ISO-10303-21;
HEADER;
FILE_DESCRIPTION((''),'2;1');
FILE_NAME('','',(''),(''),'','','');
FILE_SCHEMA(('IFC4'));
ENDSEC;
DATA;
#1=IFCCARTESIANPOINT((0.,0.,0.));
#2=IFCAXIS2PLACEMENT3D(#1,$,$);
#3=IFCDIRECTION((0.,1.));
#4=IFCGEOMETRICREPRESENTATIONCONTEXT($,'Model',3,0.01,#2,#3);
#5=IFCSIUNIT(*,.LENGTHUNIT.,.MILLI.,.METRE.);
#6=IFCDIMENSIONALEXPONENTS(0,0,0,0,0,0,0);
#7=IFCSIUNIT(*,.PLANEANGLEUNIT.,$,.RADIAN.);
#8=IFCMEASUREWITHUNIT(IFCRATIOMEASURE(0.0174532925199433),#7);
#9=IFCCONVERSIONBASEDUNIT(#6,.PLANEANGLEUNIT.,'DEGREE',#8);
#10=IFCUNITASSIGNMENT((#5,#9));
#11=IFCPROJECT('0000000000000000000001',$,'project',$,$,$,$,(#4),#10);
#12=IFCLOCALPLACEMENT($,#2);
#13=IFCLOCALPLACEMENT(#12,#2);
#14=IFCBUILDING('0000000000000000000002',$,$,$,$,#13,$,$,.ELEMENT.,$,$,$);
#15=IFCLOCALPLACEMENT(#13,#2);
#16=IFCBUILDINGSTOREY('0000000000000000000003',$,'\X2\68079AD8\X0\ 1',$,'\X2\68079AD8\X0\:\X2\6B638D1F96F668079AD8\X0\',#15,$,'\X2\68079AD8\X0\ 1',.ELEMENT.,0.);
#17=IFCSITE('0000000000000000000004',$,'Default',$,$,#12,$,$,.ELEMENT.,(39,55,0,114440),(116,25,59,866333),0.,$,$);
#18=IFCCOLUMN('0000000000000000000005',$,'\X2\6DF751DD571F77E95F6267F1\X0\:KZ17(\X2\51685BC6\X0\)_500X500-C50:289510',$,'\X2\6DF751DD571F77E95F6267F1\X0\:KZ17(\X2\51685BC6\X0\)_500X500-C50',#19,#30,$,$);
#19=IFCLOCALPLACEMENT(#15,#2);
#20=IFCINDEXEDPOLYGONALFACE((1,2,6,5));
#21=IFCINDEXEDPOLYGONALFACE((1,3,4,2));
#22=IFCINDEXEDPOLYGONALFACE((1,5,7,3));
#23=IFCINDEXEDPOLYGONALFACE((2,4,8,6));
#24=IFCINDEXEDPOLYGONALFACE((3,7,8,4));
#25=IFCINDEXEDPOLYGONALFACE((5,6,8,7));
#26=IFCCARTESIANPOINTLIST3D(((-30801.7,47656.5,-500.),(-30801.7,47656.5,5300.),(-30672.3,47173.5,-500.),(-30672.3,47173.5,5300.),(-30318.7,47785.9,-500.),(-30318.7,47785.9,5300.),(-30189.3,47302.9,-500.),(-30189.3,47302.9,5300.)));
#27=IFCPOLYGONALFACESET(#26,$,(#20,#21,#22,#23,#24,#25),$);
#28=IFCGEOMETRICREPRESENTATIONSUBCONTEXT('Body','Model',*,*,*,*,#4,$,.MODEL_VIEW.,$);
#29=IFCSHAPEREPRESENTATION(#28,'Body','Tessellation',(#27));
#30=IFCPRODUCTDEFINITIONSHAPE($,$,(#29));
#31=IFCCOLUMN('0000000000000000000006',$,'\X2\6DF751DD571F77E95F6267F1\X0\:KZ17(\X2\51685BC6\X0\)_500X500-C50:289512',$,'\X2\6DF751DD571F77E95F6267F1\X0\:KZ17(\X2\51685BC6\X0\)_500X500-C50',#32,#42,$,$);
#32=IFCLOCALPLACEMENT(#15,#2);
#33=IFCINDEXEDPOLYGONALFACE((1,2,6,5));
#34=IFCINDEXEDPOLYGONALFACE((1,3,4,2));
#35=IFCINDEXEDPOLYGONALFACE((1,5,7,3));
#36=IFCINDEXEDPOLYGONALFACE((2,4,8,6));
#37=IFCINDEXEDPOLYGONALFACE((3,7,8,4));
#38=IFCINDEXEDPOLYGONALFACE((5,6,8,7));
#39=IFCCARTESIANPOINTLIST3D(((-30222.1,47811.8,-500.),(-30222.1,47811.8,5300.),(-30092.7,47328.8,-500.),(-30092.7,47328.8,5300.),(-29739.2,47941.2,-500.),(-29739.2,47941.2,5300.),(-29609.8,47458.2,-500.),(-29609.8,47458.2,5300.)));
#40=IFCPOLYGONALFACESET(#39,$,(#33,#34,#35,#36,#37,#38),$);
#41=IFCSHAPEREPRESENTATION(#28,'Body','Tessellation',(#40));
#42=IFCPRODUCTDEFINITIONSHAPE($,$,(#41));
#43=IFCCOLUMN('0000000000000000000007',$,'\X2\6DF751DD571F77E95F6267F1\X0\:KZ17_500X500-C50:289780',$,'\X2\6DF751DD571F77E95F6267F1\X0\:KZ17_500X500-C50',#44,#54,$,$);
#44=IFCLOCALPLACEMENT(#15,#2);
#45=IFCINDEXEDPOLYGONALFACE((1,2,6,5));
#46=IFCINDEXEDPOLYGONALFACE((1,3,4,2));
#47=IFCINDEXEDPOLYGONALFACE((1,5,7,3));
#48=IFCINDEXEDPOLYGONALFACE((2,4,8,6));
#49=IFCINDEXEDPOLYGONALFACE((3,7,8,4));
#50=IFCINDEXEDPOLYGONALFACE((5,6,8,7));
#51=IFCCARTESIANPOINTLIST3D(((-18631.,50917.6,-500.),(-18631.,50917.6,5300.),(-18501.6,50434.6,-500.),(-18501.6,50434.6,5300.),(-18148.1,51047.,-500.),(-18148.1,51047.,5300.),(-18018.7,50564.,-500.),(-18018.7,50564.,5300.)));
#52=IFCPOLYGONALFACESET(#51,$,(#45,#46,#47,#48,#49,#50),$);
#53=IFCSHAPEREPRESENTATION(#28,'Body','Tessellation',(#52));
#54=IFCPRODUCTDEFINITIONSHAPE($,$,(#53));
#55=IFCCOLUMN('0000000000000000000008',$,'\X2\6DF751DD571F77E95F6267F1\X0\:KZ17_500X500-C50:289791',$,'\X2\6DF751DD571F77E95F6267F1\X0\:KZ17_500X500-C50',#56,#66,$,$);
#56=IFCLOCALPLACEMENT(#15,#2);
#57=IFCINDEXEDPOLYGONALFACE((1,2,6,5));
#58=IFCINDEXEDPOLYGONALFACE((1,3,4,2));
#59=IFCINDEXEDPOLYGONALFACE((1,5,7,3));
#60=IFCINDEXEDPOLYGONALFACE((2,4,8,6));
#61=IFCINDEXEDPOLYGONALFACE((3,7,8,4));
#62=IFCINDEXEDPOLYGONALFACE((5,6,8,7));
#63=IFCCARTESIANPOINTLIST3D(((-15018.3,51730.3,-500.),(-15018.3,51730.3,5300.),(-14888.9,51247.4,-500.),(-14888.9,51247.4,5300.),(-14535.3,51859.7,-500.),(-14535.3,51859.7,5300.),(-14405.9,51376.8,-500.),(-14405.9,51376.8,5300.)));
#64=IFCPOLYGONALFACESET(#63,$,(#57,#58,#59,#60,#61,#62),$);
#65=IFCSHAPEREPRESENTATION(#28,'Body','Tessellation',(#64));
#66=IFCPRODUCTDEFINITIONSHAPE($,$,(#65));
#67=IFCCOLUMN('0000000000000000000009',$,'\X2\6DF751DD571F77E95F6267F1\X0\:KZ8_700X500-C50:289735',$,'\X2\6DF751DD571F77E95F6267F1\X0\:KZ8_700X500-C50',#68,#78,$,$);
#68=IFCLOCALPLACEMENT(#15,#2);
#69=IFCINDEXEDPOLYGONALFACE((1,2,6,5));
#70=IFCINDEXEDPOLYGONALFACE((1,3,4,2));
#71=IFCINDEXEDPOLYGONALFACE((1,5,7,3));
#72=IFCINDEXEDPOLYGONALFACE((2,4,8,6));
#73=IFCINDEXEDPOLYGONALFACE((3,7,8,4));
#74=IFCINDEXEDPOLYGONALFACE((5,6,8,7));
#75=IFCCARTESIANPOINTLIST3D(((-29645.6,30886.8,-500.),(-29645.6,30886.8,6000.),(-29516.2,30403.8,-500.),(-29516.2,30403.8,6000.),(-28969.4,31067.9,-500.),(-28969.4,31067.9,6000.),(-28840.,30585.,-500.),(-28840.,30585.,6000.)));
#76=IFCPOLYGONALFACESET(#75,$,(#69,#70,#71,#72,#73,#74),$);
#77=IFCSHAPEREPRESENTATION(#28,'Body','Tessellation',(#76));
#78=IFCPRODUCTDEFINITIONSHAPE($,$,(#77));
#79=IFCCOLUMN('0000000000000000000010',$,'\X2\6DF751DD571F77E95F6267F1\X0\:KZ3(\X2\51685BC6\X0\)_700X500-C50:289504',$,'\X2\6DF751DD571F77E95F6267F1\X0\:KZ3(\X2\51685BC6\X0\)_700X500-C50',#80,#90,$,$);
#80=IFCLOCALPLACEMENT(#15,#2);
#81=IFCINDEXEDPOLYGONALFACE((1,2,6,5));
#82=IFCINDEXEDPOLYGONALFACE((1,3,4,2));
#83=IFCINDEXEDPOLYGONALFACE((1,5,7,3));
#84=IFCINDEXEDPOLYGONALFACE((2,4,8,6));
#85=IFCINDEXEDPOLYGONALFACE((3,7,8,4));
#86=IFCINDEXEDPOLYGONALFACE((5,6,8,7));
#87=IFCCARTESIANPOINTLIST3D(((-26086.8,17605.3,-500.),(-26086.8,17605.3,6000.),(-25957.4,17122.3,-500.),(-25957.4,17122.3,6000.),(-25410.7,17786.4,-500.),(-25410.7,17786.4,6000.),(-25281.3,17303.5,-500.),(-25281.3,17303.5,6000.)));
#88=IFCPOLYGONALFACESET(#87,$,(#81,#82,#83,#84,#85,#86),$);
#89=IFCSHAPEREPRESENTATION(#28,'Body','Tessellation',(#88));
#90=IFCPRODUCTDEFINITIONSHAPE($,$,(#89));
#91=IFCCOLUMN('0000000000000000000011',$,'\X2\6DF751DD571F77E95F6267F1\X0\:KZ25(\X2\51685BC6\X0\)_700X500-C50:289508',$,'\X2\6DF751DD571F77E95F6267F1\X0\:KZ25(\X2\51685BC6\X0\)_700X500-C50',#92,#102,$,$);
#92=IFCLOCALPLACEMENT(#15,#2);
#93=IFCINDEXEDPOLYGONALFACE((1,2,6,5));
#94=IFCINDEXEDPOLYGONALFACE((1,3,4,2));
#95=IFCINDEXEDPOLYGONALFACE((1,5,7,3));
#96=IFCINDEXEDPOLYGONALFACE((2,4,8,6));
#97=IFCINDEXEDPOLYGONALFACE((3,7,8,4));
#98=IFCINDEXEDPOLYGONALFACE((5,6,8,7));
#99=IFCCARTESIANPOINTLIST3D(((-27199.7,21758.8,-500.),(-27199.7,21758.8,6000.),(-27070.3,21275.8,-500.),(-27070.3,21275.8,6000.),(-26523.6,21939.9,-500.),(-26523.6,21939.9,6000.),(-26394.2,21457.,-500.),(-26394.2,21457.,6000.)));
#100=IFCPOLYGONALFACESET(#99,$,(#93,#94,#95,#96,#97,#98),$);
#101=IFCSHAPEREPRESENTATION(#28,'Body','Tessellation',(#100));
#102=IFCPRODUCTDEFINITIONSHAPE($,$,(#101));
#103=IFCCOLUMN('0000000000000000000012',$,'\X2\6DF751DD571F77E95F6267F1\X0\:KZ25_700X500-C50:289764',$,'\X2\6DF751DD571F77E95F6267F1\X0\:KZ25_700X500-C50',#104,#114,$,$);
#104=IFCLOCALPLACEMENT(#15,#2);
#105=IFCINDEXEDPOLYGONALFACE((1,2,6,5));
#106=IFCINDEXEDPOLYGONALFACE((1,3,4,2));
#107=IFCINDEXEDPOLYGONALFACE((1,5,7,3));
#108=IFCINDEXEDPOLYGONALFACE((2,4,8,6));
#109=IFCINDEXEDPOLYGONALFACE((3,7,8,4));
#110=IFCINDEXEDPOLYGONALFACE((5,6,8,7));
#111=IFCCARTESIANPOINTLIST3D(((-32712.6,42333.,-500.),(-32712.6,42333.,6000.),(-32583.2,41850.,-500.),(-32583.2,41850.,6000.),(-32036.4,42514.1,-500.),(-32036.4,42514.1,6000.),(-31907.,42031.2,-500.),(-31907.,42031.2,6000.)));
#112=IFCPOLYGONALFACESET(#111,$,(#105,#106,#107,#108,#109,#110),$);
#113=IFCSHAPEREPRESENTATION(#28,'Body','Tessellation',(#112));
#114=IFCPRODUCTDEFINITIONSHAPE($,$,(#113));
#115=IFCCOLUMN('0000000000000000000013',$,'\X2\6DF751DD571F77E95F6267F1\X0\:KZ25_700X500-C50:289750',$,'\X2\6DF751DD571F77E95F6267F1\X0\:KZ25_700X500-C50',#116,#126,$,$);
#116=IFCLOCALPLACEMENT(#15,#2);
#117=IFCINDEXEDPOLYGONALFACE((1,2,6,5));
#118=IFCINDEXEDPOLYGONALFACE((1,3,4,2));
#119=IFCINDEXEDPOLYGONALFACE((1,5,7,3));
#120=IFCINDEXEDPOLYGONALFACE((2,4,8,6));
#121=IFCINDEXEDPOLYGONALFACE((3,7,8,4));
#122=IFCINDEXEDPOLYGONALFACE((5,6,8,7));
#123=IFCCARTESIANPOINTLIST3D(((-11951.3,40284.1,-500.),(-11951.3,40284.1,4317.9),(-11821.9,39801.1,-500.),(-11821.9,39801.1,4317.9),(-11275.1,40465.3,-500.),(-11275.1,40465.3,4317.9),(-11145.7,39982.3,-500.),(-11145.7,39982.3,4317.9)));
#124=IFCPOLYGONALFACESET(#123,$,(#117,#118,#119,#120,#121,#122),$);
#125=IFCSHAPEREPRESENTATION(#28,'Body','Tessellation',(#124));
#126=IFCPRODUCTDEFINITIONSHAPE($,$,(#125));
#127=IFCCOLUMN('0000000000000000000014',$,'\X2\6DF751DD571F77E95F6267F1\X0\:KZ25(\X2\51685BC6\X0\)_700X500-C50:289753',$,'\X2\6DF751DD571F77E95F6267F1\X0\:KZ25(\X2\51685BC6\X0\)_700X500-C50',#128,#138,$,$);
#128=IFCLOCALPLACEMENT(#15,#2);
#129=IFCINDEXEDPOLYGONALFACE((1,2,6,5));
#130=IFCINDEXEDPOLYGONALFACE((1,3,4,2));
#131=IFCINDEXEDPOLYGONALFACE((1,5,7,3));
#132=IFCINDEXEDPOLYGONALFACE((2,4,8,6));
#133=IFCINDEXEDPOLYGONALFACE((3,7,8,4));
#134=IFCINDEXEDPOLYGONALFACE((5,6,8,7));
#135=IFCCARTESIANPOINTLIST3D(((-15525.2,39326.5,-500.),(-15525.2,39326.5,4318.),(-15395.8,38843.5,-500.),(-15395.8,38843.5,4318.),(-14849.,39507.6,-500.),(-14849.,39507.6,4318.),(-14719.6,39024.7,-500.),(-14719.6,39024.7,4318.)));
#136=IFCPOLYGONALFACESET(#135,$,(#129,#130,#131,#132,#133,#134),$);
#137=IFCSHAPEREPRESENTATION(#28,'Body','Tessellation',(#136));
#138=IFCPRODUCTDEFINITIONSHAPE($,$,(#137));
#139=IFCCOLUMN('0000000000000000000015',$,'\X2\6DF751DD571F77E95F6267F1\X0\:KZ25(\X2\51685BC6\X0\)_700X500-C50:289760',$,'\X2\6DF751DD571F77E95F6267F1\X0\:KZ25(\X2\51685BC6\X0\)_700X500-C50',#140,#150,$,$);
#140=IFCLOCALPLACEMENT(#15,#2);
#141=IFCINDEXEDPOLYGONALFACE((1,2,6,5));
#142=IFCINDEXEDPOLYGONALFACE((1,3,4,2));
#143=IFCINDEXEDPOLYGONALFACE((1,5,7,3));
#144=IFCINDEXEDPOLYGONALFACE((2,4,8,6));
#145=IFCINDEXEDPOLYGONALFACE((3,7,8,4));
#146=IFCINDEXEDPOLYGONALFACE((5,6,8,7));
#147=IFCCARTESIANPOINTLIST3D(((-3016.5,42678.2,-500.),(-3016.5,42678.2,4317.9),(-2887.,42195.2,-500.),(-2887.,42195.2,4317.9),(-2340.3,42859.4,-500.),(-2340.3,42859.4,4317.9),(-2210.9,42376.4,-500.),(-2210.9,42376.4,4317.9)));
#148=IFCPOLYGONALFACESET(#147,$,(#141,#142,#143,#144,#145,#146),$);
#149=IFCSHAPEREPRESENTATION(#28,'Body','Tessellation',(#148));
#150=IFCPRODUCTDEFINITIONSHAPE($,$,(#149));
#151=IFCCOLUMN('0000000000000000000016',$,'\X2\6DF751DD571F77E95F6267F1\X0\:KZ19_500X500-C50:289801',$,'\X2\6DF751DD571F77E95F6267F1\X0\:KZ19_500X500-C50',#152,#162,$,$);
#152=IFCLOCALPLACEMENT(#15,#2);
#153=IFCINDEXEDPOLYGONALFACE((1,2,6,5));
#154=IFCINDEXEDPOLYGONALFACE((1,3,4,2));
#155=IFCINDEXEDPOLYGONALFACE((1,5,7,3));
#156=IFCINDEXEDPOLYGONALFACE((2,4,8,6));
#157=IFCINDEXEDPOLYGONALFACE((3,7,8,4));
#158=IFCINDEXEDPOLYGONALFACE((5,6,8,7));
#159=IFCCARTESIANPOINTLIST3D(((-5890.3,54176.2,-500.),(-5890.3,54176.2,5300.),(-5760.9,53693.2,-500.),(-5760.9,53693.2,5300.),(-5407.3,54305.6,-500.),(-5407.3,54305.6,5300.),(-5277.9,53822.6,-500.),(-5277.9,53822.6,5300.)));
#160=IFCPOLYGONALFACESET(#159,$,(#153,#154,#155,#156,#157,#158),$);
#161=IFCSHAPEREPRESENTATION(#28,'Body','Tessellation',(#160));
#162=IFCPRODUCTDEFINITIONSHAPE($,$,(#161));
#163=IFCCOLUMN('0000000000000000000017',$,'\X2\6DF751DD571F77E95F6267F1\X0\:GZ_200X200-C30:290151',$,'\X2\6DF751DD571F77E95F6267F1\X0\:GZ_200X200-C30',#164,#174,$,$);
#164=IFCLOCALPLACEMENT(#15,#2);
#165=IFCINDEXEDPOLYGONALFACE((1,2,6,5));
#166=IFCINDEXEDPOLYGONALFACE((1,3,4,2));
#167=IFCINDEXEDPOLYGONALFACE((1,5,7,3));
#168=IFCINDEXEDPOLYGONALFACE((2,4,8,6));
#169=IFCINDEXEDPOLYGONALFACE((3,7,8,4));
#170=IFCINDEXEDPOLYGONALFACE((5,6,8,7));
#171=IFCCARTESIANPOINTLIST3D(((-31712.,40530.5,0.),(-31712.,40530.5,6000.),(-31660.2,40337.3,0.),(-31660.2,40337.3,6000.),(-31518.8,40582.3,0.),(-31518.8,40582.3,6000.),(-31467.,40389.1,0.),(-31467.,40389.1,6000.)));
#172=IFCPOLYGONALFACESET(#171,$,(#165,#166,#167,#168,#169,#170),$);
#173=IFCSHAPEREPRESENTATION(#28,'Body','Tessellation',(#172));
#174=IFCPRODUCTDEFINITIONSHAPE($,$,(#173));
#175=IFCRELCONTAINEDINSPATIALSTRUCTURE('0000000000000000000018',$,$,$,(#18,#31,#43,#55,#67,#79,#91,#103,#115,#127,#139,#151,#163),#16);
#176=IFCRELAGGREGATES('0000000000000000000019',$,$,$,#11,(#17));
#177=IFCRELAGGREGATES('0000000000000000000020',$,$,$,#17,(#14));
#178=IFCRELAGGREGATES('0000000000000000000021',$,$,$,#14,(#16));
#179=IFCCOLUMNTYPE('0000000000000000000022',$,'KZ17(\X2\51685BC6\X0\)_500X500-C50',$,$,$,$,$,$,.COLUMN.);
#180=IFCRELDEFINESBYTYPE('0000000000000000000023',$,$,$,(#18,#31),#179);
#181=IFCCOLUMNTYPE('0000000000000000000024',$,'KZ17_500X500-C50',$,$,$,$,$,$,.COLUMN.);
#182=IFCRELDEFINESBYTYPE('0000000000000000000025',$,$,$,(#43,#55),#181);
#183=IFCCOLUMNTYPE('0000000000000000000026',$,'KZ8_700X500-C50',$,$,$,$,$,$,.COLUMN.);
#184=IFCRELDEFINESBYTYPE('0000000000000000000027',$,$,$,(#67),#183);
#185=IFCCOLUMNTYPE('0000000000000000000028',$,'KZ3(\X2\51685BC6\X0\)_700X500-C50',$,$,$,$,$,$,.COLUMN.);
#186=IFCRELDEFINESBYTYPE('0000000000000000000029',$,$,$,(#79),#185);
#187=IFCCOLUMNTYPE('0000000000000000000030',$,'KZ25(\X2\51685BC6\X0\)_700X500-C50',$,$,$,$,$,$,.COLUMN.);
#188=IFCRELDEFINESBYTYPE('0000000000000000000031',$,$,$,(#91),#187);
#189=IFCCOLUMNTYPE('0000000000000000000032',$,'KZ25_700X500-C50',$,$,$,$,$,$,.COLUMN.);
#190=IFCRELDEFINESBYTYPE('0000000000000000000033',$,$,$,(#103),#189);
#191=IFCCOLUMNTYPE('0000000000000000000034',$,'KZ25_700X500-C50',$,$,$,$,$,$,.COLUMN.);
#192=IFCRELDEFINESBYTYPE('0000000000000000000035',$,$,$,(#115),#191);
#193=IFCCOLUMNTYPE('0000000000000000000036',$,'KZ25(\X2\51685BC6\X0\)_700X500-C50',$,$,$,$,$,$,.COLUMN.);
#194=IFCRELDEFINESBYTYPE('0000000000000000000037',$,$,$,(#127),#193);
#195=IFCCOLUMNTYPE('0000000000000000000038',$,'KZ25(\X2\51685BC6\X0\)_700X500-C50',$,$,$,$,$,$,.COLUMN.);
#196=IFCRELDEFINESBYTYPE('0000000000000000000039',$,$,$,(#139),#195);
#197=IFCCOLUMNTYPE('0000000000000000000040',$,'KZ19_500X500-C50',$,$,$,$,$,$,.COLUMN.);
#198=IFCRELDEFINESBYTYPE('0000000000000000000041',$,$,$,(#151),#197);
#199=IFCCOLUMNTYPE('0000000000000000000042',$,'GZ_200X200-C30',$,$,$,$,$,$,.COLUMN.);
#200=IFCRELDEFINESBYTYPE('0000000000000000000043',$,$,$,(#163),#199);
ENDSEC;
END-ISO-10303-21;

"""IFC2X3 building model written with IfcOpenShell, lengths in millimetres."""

from ifc_helpers import new_model, entity, si_unit, converted_unit, direction, frame, origin, origin_2d_with_axis, place, context, subcontext, project, spatial, rectangle, extrude, source, transform, mapped, type_object, type_shapes, element, save


model = new_model("IFC2X3")

# Units and contexts
model_context = context("Model", 3, precision=0.01, world=origin(), true_north=direction((0.0, 1.0)))
body_context = subcontext(model_context, "Body", "Model", "MODEL_VIEW")
ifc_project = project(units=[si_unit("LENGTHUNIT", "METRE", prefix="MILLI"), converted_unit("PLANEANGLEUNIT", "DEGREE", entity("IfcRatioMeasure", 0.0174532925199433), si_unit("PLANEANGLEUNIT", "RADIAN"), dimensions=[0, 0, 0, 0, 0, 0, 0])], contexts=[model_context])

# Site, building, storey
site_placement = place(None, origin())
site = spatial("IfcSite", under=ifc_project, at=site_placement, Name="Default", CompositionType="ELEMENT", RefLatitude=(39, 55, 0, 114440), RefLongitude=(116, 25, 59, 866333), RefElevation=0.0)
building_placement = place(site_placement, origin())
building = spatial("IfcBuilding", under=site, at=building_placement, CompositionType="ELEMENT")
storey_placement = place(building_placement, origin())
storey = spatial("IfcBuildingStorey", under=building, at=storey_placement, Name="标高 1", ObjectType="标高:正负零标高", LongName="标高 1", CompositionType="ELEMENT", Elevation=0.0)

# Columns
column_type_1 = type_object("IfcColumnType", Name="KZ17(全密)_500X500-C50", PredefinedType="COLUMN")
shared_shape_1 = source(origin(), body_context, "Body", "SweptSolid", [
    extrude(rectangle(XDim=500.0, YDim=500.0, at=origin_2d_with_axis()), frame((0.0, 0.0, -500.0), z_axis=(0.0, 0.0, 1.0), x_axis=(0.0, -1.0, 0.0)), (0.0, 0.0, 1.0), 5800.0),
])
type_shapes(column_type_1, [shared_shape_1])
for number, where, z_axis, x_axis, name in (
    (1, (-30495.5, 47479.7, 0.0), (0.0, 0.0, 1.0), (0.258819, -0.965926, 0.0), "混凝土矩形柱:KZ17(全密)_500X500-C50:289510"),
    (2, (-29915.9, 47635.0, 0.0), (0.0, 0.0, 1.0), (0.258819, -0.965926, 0.0), "混凝土矩形柱:KZ17(全密)_500X500-C50:289512"),
):
    element("IfcColumn", number, at=place(building_placement, frame(where, z_axis=z_axis, x_axis=x_axis)), inside=storey, type_object=column_type_1, Name=name, ObjectType="混凝土矩形柱:KZ17(全密)_500X500-C50", context=body_context, shape_type="MappedRepresentation", body=[
        mapped(shared_shape_1, transform((0.0, 0.0, 0.0), scale=1.0)),
    ])
column_type_2 = type_object("IfcColumnType", Name="KZ17_500X500-C50", PredefinedType="COLUMN")
shared_shape_2 = source(origin(), body_context, "Body", "SweptSolid", [
    extrude(rectangle(XDim=500.0, YDim=500.0, at=origin_2d_with_axis()), frame((0.0, 0.0, -500.0), z_axis=(0.0, 0.0, 1.0), x_axis=(0.0, -1.0, 0.0)), (0.0, 0.0, 1.0), 5800.0),
])
type_shapes(column_type_2, [shared_shape_2])
for number, where, z_axis, x_axis, name in (
    (3, (-18324.8, 50740.8, 0.0), (0.0, 0.0, 1.0), (0.258819, -0.965926, 0.0), "混凝土矩形柱:KZ17_500X500-C50:289780"),
    (4, (-14712.1, 51553.5, 0.0), (0.0, 0.0, 1.0), (0.258819, -0.965926, 0.0), "混凝土矩形柱:KZ17_500X500-C50:289791"),
):
    element("IfcColumn", number, at=place(building_placement, frame(where, z_axis=z_axis, x_axis=x_axis)), inside=storey, type_object=column_type_2, Name=name, ObjectType="混凝土矩形柱:KZ17_500X500-C50", context=body_context, shape_type="MappedRepresentation", body=[
        mapped(shared_shape_2, transform((0.0, 0.0, 0.0), scale=1.0)),
    ])
column_type_3 = type_object("IfcColumnType", Name="KZ8_700X500-C50", PredefinedType="COLUMN")
shared_shape_3 = source(origin(), body_context, "Body", "SweptSolid", [
    extrude(rectangle(XDim=500.0, YDim=700.0, at=origin_2d_with_axis()), frame((0.0, 0.0, -500.0), z_axis=(0.0, 0.0, 1.0), x_axis=(0.0, -1.0, 0.0)), (0.0, 0.0, 1.0), 6500.0),
])
type_shapes(column_type_3, [shared_shape_3])
column_1_placement = place(building_placement, frame((-29242.8, 30735.9, 0.0), z_axis=(0.0, 0.0, 1.0), x_axis=(0.965926, 0.258819, 0.0)))
element("IfcColumn", 5, at=column_1_placement, inside=storey, type_object=column_type_3, Name="混凝土矩形柱:KZ8_700X500-C50:289735", ObjectType="混凝土矩形柱:KZ8_700X500-C50", context=body_context, shape_type="MappedRepresentation", body=[
    mapped(shared_shape_3, transform((0.0, 0.0, 0.0), scale=1.0)),
])
column_type_4 = type_object("IfcColumnType", Name="KZ3(全密)_700X500-C50", PredefinedType="COLUMN")
shared_shape_4 = source(origin(), body_context, "Body", "SweptSolid", [
    extrude(rectangle(XDim=500.0, YDim=700.0, at=origin_2d_with_axis()), frame((0.0, 0.0, -500.0), z_axis=(0.0, 0.0, 1.0), x_axis=(0.0, -1.0, 0.0)), (0.0, 0.0, 1.0), 6500.0),
])
type_shapes(column_type_4, [shared_shape_4])
column_2_placement = place(building_placement, frame((-25684.0, 17454.4, 0.0), z_axis=(0.0, 0.0, 1.0), x_axis=(0.965926, 0.258819, 0.0)))
element("IfcColumn", 6, at=column_2_placement, inside=storey, type_object=column_type_4, Name="混凝土矩形柱:KZ3(全密)_700X500-C50:289504", ObjectType="混凝土矩形柱:KZ3(全密)_700X500-C50", context=body_context, shape_type="MappedRepresentation", body=[
    mapped(shared_shape_4, transform((0.0, 0.0, 0.0), scale=1.0)),
])
column_type_5 = type_object("IfcColumnType", Name="KZ25(全密)_700X500-C50", PredefinedType="COLUMN")
shared_shape_5 = source(origin(), body_context, "Body", "SweptSolid", [
    extrude(rectangle(XDim=500.0, YDim=700.0, at=origin_2d_with_axis()), frame((0.0, 0.0, -500.0), z_axis=(0.0, 0.0, 1.0), x_axis=(0.0, -1.0, 0.0)), (0.0, 0.0, 1.0), 6500.0),
])
type_shapes(column_type_5, [shared_shape_5])
column_3_placement = place(building_placement, frame((-26797.0, 21607.9, 0.0), z_axis=(0.0, 0.0, 1.0), x_axis=(0.965926, 0.258819, 0.0)))
element("IfcColumn", 7, at=column_3_placement, inside=storey, type_object=column_type_5, Name="混凝土矩形柱:KZ25(全密)_700X500-C50:289508", ObjectType="混凝土矩形柱:KZ25(全密)_700X500-C50", context=body_context, shape_type="MappedRepresentation", body=[
    mapped(shared_shape_5, transform((0.0, 0.0, 0.0), scale=1.0)),
])
column_type_6 = type_object("IfcColumnType", Name="KZ25_700X500-C50", PredefinedType="COLUMN")
shared_shape_6 = source(origin(), body_context, "Body", "SweptSolid", [
    extrude(rectangle(XDim=500.0, YDim=700.0, at=origin_2d_with_axis()), frame((0.0, 0.0, -500.0), z_axis=(0.0, 0.0, 1.0), x_axis=(0.0, -1.0, 0.0)), (0.0, 0.0, 1.0), 6500.0),
])
type_shapes(column_type_6, [shared_shape_6])
column_4_placement = place(building_placement, frame((-32309.8, 42182.1, 0.0), z_axis=(0.0, 0.0, 1.0), x_axis=(0.965926, 0.258819, 0.0)))
element("IfcColumn", 8, at=column_4_placement, inside=storey, type_object=column_type_6, Name="混凝土矩形柱:KZ25_700X500-C50:289764", ObjectType="混凝土矩形柱:KZ25_700X500-C50", context=body_context, shape_type="MappedRepresentation", body=[
    mapped(shared_shape_6, transform((0.0, 0.0, 0.0), scale=1.0)),
])
column_type_7 = type_object("IfcColumnType", Name="KZ25_700X500-C50", PredefinedType="COLUMN")
shared_shape_7 = source(origin(), body_context, "Body", "SweptSolid", [
    extrude(rectangle(XDim=500.0, YDim=700.0, at=origin_2d_with_axis()), frame((0.0, 0.0, -500.0), z_axis=(0.0, 0.0, 1.0), x_axis=(0.0, -1.0, 0.0)), (0.0, 0.0, 1.0), 4817.9),
])
type_shapes(column_type_7, [shared_shape_7])
column_5_placement = place(building_placement, frame((-11548.5, 40133.2, 0.0), z_axis=(0.0, 0.0, 1.0), x_axis=(0.965926, 0.258819, 0.0)))
element("IfcColumn", 9, at=column_5_placement, inside=storey, type_object=column_type_7, Name="混凝土矩形柱:KZ25_700X500-C50:289750", ObjectType="混凝土矩形柱:KZ25_700X500-C50", context=body_context, shape_type="MappedRepresentation", body=[
    mapped(shared_shape_7, transform((0.0, 0.0, 0.0), scale=1.0)),
])
column_type_8 = type_object("IfcColumnType", Name="KZ25(全密)_700X500-C50", PredefinedType="COLUMN")
shared_shape_8 = source(origin(), body_context, "Body", "SweptSolid", [
    extrude(rectangle(XDim=500.0, YDim=700.0, at=origin_2d_with_axis()), frame((0.0, 0.0, -500.0), z_axis=(0.0, 0.0, 1.0), x_axis=(0.0, -1.0, 0.0)), (0.0, 0.0, 1.0), 4818.0),
])
type_shapes(column_type_8, [shared_shape_8])
column_6_placement = place(building_placement, frame((-15122.4, 39175.6, 0.0), z_axis=(0.0, 0.0, 1.0), x_axis=(0.965926, 0.258819, 0.0)))
element("IfcColumn", 10, at=column_6_placement, inside=storey, type_object=column_type_8, Name="混凝土矩形柱:KZ25(全密)_700X500-C50:289753", ObjectType="混凝土矩形柱:KZ25(全密)_700X500-C50", context=body_context, shape_type="MappedRepresentation", body=[
    mapped(shared_shape_8, transform((0.0, 0.0, 0.0), scale=1.0)),
])
column_type_9 = type_object("IfcColumnType", Name="KZ25(全密)_700X500-C50", PredefinedType="COLUMN")
shared_shape_9 = source(origin(), body_context, "Body", "SweptSolid", [
    extrude(rectangle(XDim=500.0, YDim=700.0, at=origin_2d_with_axis()), frame((0.0, 0.0, -500.0), z_axis=(0.0, 0.0, 1.0), x_axis=(0.0, -1.0, 0.0)), (0.0, 0.0, 1.0), 4817.9),
])
type_shapes(column_type_9, [shared_shape_9])
column_7_placement = place(building_placement, frame((-2613.7, 42527.3, 0.0), z_axis=(0.0, 0.0, 1.0), x_axis=(0.965926, 0.258819, 0.0)))
element("IfcColumn", 11, at=column_7_placement, inside=storey, type_object=column_type_9, Name="混凝土矩形柱:KZ25(全密)_700X500-C50:289760", ObjectType="混凝土矩形柱:KZ25(全密)_700X500-C50", context=body_context, shape_type="MappedRepresentation", body=[
    mapped(shared_shape_9, transform((0.0, 0.0, 0.0), scale=1.0)),
])
column_type_10 = type_object("IfcColumnType", Name="KZ19_500X500-C50", PredefinedType="COLUMN")
shared_shape_10 = source(origin(), body_context, "Body", "SweptSolid", [
    extrude(rectangle(XDim=500.0, YDim=500.0, at=origin_2d_with_axis()), frame((0.0, 0.0, -500.0), z_axis=(0.0, 0.0, 1.0), x_axis=(0.0, -1.0, 0.0)), (0.0, 0.0, 1.0), 5800.0),
])
type_shapes(column_type_10, [shared_shape_10])
column_8_placement = place(building_placement, frame((-5584.1, 53999.4, 0.0), z_axis=(0.0, 0.0, 1.0), x_axis=(0.258819, -0.965926, 0.0)))
element("IfcColumn", 12, at=column_8_placement, inside=storey, type_object=column_type_10, Name="混凝土矩形柱:KZ19_500X500-C50:289801", ObjectType="混凝土矩形柱:KZ19_500X500-C50", context=body_context, shape_type="MappedRepresentation", body=[
    mapped(shared_shape_10, transform((0.0, 0.0, 0.0), scale=1.0)),
])
column_type_11 = type_object("IfcColumnType", Name="GZ_200X200-C30", PredefinedType="COLUMN")
shared_shape_11 = source(origin(), body_context, "Body", "SweptSolid", [
    extrude(rectangle(XDim=200.0, YDim=200.0, at=origin_2d_with_axis()), frame((0.0, 0.0, 0.0), z_axis=(0.0, 0.0, 1.0), x_axis=(0.0, -1.0, 0.0)), (0.0, 0.0, 1.0), 6000.0),
])
type_shapes(column_type_11, [shared_shape_11])
for number, where, z_axis, x_axis, name in (
    (13, (-31589.5, 40459.8, 0.0), (0.0, 0.0, 1.0), (0.965926, 0.258819, 0.0), "混凝土矩形柱:GZ_200X200-C30:290151"),
):
    element("IfcColumn", number, at=place(building_placement, frame(where, z_axis=z_axis, x_axis=x_axis)), inside=storey, type_object=column_type_11, Name=name, ObjectType="混凝土矩形柱:GZ_200X200-C30", context=body_context, shape_type="MappedRepresentation", body=[
        mapped(shared_shape_11, transform((0.0, 0.0, 0.0), scale=1.0)),
    ])

save(model, "model.ifc")
